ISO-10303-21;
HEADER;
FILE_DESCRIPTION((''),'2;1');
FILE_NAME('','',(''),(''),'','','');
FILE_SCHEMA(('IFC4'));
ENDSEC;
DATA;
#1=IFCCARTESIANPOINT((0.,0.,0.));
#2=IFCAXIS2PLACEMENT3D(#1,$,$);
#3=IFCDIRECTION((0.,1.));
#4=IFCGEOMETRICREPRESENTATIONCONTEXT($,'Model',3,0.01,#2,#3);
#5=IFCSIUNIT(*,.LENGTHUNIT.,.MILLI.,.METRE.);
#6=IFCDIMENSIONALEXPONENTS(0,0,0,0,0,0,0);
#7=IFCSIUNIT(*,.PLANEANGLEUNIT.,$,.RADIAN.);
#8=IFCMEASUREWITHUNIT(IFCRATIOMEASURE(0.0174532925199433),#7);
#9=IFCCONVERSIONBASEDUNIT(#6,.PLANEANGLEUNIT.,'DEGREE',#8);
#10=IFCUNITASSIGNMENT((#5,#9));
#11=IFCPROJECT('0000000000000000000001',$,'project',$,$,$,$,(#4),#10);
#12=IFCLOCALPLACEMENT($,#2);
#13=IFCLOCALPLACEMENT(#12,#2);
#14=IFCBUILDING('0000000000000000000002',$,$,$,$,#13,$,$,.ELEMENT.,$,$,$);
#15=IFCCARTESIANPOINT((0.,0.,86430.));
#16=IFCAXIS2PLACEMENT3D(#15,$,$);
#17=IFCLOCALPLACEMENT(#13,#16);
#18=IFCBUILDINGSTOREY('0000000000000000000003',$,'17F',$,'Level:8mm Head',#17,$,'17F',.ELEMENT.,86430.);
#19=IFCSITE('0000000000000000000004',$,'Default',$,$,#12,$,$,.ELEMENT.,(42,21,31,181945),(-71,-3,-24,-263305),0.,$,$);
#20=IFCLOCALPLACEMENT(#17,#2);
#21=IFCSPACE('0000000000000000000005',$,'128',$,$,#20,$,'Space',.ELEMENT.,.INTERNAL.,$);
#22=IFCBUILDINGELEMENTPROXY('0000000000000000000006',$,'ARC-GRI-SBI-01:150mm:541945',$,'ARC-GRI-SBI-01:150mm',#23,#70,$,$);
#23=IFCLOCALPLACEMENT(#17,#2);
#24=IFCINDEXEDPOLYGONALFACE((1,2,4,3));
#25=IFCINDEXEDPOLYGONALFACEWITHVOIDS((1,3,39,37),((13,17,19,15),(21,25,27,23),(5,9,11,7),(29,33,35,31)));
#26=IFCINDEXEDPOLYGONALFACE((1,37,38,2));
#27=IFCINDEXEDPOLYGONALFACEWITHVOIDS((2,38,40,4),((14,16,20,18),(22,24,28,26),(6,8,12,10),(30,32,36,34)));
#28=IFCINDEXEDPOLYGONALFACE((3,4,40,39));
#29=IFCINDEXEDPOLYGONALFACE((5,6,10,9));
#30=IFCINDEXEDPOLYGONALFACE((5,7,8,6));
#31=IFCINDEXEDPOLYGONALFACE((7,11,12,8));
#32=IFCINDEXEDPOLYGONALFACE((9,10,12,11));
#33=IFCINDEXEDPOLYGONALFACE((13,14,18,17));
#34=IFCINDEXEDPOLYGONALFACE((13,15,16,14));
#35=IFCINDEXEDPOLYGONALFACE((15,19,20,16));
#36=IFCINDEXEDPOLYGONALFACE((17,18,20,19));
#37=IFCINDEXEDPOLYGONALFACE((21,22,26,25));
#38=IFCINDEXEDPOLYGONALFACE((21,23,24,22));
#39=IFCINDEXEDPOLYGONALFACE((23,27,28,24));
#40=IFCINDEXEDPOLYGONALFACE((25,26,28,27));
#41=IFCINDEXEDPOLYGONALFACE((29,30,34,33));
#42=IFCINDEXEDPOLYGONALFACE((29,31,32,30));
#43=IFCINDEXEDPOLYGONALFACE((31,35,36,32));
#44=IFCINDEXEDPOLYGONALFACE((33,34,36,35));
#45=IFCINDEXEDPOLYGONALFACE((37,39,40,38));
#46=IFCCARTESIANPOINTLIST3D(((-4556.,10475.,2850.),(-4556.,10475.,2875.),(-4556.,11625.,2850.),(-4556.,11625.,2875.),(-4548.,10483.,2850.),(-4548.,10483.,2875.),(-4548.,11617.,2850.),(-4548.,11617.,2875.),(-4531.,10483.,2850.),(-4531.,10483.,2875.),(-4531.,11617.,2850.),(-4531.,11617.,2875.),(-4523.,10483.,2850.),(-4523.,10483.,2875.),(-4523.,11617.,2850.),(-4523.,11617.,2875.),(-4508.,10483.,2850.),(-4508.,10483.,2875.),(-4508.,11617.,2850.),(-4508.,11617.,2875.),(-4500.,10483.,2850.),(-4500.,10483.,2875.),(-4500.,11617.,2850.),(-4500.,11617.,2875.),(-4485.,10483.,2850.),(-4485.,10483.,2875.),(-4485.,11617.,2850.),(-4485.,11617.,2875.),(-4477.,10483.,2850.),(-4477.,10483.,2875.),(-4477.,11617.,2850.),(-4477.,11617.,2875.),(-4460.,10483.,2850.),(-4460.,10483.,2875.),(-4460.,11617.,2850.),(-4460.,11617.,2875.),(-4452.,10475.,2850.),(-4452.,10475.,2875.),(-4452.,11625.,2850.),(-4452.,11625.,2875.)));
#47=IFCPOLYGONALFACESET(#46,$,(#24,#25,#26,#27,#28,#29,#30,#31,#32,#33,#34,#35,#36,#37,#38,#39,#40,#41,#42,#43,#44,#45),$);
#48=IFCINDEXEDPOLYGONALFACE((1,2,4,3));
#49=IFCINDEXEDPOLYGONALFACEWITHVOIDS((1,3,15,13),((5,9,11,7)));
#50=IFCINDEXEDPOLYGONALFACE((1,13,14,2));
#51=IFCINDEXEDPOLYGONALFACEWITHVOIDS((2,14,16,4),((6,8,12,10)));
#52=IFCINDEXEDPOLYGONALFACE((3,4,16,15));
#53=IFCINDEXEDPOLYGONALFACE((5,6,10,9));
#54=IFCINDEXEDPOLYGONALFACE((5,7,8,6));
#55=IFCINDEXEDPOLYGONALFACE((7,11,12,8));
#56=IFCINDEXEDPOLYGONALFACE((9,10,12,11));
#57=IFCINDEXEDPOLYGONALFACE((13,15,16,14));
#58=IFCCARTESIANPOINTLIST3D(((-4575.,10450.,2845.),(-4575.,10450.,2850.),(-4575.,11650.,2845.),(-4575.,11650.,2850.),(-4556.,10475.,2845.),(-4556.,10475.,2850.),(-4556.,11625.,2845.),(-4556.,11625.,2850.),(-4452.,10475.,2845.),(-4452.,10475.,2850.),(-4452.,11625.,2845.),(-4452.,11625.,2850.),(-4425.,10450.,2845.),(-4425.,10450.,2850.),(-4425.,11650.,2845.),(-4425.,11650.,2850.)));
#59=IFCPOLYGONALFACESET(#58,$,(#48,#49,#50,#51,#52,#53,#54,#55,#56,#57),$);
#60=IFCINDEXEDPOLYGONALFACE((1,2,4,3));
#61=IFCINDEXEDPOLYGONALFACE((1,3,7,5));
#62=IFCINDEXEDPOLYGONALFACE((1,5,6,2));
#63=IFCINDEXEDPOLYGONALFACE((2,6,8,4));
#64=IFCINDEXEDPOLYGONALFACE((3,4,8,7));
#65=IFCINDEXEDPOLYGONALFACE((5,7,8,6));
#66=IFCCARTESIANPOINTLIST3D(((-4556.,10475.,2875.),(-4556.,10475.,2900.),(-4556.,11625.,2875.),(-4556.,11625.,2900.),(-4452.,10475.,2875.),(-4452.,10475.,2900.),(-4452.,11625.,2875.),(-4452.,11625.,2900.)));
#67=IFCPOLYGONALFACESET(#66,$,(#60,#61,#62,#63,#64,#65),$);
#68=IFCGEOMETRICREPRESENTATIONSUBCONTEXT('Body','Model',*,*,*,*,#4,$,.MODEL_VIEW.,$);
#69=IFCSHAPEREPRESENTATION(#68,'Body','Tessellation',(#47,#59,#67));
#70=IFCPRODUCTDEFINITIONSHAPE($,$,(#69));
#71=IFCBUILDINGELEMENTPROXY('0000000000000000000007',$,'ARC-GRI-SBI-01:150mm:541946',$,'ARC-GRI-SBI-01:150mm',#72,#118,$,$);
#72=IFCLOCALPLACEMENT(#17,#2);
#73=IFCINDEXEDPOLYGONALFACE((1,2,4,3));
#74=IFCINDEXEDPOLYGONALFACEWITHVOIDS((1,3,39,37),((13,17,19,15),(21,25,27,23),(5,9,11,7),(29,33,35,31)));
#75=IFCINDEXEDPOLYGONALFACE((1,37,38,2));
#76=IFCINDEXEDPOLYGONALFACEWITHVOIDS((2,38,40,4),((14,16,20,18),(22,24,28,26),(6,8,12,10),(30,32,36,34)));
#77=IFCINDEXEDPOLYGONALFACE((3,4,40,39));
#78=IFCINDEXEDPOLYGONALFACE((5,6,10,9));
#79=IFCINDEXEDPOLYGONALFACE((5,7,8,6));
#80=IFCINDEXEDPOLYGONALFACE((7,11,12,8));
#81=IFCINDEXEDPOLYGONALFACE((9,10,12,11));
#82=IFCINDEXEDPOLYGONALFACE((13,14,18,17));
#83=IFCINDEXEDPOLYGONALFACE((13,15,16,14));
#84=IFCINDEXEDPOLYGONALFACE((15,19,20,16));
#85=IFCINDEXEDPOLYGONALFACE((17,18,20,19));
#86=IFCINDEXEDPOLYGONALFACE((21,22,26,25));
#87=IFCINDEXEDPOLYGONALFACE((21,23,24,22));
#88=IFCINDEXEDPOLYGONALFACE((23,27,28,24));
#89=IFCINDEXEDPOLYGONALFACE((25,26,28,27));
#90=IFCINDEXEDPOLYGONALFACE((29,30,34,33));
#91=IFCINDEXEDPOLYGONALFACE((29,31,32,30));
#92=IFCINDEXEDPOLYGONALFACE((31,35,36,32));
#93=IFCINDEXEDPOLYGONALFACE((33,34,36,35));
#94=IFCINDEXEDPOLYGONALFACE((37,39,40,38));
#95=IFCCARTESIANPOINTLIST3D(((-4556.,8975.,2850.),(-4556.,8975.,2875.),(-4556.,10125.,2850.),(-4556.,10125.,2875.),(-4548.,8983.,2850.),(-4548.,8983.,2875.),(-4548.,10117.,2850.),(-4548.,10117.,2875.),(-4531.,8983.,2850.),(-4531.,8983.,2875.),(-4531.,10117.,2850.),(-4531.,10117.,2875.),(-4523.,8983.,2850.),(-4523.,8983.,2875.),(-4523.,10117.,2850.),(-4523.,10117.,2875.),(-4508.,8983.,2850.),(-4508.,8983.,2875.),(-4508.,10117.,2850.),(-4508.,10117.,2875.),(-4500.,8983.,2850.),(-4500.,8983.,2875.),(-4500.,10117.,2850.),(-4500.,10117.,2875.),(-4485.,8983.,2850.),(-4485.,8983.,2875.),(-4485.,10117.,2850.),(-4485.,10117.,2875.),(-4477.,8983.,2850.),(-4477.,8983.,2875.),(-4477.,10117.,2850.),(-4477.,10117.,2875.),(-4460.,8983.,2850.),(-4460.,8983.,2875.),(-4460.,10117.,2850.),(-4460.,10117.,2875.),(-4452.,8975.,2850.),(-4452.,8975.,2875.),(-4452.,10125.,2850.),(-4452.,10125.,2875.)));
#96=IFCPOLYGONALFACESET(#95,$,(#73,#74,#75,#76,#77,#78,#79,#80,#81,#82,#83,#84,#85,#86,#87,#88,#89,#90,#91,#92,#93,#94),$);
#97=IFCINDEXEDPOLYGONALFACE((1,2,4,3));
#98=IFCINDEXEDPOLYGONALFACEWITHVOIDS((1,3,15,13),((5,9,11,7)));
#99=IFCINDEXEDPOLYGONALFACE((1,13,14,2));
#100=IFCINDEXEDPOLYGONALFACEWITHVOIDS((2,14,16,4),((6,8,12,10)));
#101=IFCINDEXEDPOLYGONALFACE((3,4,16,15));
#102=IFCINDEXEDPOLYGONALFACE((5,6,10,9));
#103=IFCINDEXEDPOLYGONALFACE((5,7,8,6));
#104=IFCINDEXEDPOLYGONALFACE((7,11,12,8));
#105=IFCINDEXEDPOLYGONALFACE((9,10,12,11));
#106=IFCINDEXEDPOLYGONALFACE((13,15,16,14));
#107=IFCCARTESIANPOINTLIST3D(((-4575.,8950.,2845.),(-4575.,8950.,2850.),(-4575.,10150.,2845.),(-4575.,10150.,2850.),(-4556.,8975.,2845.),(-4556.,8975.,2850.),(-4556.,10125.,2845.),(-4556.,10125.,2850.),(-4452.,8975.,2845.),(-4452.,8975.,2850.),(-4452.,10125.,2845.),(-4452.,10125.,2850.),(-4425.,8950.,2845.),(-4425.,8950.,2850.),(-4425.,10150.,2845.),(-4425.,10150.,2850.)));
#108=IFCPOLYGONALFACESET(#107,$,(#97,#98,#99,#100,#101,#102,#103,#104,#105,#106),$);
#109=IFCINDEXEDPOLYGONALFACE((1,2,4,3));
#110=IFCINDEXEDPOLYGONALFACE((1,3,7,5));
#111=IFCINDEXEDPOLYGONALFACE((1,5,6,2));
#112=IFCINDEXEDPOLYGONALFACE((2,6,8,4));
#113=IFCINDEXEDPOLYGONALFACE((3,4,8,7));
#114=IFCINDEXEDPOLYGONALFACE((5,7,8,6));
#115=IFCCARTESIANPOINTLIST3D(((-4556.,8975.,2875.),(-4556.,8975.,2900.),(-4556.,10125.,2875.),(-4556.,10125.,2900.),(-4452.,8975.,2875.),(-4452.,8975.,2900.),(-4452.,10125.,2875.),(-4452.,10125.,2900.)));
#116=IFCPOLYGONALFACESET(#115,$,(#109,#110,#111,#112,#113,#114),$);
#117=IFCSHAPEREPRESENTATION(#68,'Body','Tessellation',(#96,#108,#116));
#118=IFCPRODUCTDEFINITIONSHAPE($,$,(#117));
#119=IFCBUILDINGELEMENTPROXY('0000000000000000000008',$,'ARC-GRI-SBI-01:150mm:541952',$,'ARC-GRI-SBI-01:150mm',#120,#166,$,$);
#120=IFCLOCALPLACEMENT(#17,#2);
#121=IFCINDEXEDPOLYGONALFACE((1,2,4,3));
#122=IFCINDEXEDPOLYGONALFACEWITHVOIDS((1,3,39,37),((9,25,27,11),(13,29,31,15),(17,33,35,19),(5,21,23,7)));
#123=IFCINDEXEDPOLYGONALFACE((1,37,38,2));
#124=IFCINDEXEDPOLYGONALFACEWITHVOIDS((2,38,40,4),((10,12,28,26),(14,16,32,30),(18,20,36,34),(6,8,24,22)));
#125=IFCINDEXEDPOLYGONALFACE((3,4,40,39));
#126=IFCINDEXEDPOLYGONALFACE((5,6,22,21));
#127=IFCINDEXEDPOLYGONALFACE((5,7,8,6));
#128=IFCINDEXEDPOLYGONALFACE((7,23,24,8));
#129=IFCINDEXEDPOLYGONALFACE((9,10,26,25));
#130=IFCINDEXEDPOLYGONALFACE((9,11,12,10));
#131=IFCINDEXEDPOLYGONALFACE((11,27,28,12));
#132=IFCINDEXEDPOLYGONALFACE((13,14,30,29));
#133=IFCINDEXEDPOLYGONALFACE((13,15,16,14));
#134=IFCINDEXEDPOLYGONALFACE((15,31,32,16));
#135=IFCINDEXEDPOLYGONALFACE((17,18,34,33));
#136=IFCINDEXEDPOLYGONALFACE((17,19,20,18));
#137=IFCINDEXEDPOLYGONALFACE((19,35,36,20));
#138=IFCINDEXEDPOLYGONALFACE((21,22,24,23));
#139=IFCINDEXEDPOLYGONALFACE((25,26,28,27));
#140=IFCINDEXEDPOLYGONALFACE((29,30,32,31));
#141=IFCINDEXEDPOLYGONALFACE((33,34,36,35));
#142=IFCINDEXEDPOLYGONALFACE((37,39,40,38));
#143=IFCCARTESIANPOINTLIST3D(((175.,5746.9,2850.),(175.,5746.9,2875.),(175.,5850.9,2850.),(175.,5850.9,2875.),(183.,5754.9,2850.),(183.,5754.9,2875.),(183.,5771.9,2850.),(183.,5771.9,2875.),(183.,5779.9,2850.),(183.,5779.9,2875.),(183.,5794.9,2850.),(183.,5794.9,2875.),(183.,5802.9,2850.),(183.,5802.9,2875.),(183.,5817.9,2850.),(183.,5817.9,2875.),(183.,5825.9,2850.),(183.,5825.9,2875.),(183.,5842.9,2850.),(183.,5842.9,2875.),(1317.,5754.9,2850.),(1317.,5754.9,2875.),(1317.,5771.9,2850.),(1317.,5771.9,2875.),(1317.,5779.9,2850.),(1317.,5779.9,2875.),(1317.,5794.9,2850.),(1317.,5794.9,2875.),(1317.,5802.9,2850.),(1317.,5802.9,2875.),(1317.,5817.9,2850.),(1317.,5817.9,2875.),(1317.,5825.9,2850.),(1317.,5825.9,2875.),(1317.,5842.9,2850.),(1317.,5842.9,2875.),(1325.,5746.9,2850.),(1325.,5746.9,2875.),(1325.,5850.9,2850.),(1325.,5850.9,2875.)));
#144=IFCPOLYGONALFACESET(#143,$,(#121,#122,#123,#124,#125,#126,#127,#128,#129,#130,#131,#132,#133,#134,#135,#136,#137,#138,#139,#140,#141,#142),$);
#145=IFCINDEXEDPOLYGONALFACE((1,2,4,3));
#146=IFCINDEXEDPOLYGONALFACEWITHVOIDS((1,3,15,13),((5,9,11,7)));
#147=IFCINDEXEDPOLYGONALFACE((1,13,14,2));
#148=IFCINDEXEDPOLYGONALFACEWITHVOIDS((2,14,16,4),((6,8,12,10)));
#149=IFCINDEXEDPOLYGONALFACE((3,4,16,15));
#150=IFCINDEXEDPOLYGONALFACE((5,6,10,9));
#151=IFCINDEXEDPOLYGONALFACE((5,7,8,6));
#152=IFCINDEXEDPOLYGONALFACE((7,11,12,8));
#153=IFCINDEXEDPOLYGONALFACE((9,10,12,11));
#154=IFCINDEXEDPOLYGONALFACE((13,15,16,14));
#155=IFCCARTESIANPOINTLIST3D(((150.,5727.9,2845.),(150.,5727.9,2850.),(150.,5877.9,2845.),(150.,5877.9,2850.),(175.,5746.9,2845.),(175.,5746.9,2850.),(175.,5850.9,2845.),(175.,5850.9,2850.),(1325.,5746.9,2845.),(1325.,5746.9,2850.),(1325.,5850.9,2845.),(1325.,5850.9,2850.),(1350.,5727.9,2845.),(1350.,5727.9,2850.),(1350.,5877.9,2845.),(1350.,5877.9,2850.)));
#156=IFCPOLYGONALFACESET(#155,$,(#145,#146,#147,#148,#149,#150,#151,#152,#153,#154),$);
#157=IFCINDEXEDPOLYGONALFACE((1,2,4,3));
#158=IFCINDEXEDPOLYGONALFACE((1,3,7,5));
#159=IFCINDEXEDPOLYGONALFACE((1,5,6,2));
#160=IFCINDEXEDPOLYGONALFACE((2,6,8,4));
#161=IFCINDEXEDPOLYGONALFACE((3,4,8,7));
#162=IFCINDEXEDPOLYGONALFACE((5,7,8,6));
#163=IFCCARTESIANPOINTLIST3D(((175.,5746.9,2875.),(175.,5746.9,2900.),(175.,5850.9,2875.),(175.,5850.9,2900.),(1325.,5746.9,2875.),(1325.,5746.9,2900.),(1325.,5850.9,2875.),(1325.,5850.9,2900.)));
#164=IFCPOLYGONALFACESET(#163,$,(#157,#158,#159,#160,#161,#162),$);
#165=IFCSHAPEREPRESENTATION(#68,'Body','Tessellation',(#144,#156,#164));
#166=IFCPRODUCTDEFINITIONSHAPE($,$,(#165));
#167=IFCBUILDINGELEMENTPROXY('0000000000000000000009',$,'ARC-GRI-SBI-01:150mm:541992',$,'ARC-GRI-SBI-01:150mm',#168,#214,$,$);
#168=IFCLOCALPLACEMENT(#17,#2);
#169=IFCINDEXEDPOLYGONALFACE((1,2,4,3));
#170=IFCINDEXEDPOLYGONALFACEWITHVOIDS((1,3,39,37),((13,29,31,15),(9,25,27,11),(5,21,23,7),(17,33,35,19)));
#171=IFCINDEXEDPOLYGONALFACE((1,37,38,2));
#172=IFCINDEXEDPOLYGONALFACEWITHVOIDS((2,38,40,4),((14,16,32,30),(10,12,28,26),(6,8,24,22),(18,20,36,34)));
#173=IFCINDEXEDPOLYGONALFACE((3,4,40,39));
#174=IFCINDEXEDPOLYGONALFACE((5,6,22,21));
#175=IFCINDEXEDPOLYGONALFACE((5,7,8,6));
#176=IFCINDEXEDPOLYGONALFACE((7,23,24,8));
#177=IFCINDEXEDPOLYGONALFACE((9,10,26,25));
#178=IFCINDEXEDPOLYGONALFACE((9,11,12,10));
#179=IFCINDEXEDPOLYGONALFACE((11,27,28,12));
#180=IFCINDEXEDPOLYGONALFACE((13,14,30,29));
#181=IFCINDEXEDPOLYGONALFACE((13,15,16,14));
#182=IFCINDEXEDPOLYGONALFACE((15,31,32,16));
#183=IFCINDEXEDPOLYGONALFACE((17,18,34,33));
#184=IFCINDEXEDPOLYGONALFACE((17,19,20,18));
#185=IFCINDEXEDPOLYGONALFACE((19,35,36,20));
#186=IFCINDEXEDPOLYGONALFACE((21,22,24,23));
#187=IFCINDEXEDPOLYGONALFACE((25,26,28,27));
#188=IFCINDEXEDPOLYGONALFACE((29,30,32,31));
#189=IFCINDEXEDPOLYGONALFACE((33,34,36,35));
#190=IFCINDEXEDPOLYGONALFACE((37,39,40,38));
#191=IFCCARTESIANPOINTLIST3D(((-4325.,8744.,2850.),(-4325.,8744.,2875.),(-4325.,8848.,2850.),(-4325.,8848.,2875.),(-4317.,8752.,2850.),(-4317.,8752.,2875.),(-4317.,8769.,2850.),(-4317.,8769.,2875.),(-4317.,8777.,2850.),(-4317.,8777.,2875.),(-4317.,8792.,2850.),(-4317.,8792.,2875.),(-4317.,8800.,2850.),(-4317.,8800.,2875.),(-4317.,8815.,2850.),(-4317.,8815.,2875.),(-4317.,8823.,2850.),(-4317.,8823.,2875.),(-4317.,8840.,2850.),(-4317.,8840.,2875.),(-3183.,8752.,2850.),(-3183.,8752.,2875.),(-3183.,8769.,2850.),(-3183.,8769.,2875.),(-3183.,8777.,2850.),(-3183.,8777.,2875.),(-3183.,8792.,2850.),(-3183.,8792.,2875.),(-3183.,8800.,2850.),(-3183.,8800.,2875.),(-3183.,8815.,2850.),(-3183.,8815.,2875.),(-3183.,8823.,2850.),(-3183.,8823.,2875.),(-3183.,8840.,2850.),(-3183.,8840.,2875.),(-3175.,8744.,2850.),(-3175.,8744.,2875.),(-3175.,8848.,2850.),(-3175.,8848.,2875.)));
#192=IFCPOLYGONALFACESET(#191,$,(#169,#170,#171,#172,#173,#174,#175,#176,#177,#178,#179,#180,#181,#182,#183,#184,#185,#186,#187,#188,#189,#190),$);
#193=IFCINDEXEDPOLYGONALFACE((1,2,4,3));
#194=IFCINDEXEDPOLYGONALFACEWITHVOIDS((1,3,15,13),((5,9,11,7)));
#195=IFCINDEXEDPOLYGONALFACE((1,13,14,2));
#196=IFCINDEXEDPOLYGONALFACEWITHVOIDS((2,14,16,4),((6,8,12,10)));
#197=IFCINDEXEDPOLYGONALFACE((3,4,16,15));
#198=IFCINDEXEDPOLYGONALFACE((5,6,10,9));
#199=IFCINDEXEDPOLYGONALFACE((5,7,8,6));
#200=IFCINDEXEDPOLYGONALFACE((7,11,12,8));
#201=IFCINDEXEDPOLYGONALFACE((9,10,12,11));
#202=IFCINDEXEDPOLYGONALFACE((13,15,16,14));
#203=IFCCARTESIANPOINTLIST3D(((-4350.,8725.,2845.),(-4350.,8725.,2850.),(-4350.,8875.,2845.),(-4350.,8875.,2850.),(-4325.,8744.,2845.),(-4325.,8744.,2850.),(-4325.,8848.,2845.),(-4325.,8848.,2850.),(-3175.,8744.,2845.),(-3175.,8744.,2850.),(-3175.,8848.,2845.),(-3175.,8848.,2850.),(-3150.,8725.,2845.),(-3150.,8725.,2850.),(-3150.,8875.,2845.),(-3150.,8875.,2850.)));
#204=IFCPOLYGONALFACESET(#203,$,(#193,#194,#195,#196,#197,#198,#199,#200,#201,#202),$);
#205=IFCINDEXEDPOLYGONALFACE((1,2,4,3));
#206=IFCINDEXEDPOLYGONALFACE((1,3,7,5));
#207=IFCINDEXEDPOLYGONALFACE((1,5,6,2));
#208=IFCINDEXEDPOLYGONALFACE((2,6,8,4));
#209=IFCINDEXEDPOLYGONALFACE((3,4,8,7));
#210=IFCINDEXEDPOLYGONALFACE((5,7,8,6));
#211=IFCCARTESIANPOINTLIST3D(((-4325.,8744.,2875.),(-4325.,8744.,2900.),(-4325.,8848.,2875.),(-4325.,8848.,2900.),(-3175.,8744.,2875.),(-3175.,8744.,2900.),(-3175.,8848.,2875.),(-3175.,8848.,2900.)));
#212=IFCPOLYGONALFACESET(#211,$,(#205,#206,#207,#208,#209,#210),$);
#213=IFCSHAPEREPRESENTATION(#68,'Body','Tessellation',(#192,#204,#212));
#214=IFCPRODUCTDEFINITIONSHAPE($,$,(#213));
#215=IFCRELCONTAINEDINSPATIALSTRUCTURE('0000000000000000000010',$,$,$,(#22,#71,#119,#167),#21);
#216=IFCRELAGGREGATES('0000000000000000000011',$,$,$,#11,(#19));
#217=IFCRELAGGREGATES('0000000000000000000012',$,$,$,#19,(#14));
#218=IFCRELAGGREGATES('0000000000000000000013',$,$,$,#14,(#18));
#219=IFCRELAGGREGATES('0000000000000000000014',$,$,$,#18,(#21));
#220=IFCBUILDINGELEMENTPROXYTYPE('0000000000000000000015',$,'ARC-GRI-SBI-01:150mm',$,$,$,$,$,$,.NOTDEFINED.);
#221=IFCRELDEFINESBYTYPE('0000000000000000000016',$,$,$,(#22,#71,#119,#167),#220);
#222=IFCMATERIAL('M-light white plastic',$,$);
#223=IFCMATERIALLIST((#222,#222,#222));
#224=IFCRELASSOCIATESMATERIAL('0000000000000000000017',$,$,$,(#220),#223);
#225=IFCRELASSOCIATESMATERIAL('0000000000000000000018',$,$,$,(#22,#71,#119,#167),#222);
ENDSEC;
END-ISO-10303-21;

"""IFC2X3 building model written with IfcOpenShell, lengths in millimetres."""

from ifc_helpers import new_model, entity, si_unit, converted_unit, direction, frame, origin, origin_2d_with_axis, place, context, subcontext, project, spatial, polyline, rectangle, outline, extrude, source, transform, mapped, material, material_list, type_object, type_shapes, element, save


model = new_model("IFC2X3")

# Units and contexts
model_context = context("Model", 3, precision=0.01, world=origin(), true_north=direction((0.0, 1.0)))
body_context = subcontext(model_context, "Body", "Model", "MODEL_VIEW")
ifc_project = project(units=[si_unit("LENGTHUNIT", "METRE", prefix="MILLI"), converted_unit("PLANEANGLEUNIT", "DEGREE", entity("IfcRatioMeasure", 0.0174532925199433), si_unit("PLANEANGLEUNIT", "RADIAN"), dimensions=[0, 0, 0, 0, 0, 0, 0])], contexts=[model_context])

# Site, building, storey
site_placement = place(None, origin())
site = spatial("IfcSite", under=ifc_project, at=site_placement, Name="Default", CompositionType="ELEMENT", RefLatitude=(42, 21, 31, 181945), RefLongitude=(-71, -3, -24, -263305), RefElevation=0.0)
building_placement = place(site_placement, origin())
building = spatial("IfcBuilding", under=site, at=building_placement, CompositionType="ELEMENT")
storey_placement = place(building_placement, frame((0.0, 0.0, 86430.0)))
storey = spatial("IfcBuildingStorey", under=building, at=storey_placement, Name="17F", ObjectType="Level:8mm Head", LongName="17F", CompositionType="ELEMENT", Elevation=86430.0)

# Shared definitions
space_placement = place(storey_placement, origin())
space = spatial("IfcSpace", under=storey, at=space_placement, Name="128", LongName="Space", CompositionType="ELEMENT", InteriorOrExteriorSpace="INTERNAL")

# Building element proxies
ifc_material_1 = material(Name="M-light white plastic")
ifc_material_list = material_list([ifc_material_1, ifc_material_1, ifc_material_1])
building_element_proxy_type = type_object("IfcBuildingElementProxyType", Name="ARC-GRI-SBI-01:150mm", PredefinedType="NOTDEFINED", material=ifc_material_list)
shared_shape = source(origin(), body_context, "Body", "SweptSolid", [
    extrude(outline(polyline([(-575.0, -52.0), (575.0, -52.0), (575.0, 52.0), (-575.0, 52.0), (-575.0, -52.0)]), holes=[polyline([(-567.0, -44.0), (-567.0, -27.0), (567.0, -27.0), (567.0, -44.0), (-567.0, -44.0)]), polyline([(567.0, -4.0), (567.0, -19.0), (-567.0, -19.0), (-567.0, -4.0), (567.0, -4.0)]), polyline([(-567.0, 44.0), (567.0, 44.0), (567.0, 27.0), (-567.0, 27.0), (-567.0, 44.0)]), polyline([(567.0, 4.0), (-567.0, 4.0), (-567.0, 19.0), (567.0, 19.0), (567.0, 4.0)])]), frame((425.0, 4.0, 4000.0), z_axis=(0.0, 0.0, 1.0), x_axis=(-1.0, 0.0, 0.0)), (0.0, 0.0, 1.0), 25.0),
    extrude(outline(polyline([(-600.0, -75.0), (600.0, -75.0), (600.0, 75.0), (-600.0, 75.0), (-600.0, -75.0)]), holes=[polyline([(-575.0, -56.0), (-575.0, 48.0), (575.0, 48.0), (575.0, -56.0), (-575.0, -56.0)])]), frame((425.0, 0.0, 3995.0), z_axis=(0.0, 0.0, 1.0), x_axis=(-1.0, 0.0, 0.0)), (0.0, 0.0, 1.0), 5.0),
    extrude(rectangle(XDim=1150.0, YDim=104.0, at=origin_2d_with_axis()), frame((425.0, 4.0, 4025.0), z_axis=(0.0, 0.0, 1.0), x_axis=(-1.0, 0.0, 0.0)), (0.0, 0.0, 1.0), 25.0),
])
type_shapes(building_element_proxy_type, [shared_shape])
for number, where, z_axis, x_axis, name in (
    (1, (-4500.0, 10625.0, -1150.0), (0.0, 0.0, 1.0), (0.0, 1.0, 0.0), "ARC-GRI-SBI-01:150mm:541945"),
    (2, (-4500.0, 9125.0, -1150.0), (0.0, 0.0, 1.0), (0.0, 1.0, 0.0), "ARC-GRI-SBI-01:150mm:541946"),
    (3, (1175.0, 5802.9, -1150.0), (0.0, 0.0, 1.0), (-1.0, 0.0, 0.0), "ARC-GRI-SBI-01:150mm:541952"),
    (4, (-3325.0, 8800.0, -1150.0), (0.0, 0.0, 1.0), (-1.0, 0.0, 0.0), "ARC-GRI-SBI-01:150mm:541992"),
):
    element("IfcBuildingElementProxy", number, at=place(space_placement, frame(where, z_axis=z_axis, x_axis=x_axis)), inside=space, type_object=building_element_proxy_type, material=ifc_material_1, Name=name, ObjectType="ARC-GRI-SBI-01:150mm", context=body_context, shape_type="MappedRepresentation", body=[
        mapped(shared_shape, transform((0.0, 0.0, 0.0), scale=1.0)),
    ])

save(model, "model.ifc")
